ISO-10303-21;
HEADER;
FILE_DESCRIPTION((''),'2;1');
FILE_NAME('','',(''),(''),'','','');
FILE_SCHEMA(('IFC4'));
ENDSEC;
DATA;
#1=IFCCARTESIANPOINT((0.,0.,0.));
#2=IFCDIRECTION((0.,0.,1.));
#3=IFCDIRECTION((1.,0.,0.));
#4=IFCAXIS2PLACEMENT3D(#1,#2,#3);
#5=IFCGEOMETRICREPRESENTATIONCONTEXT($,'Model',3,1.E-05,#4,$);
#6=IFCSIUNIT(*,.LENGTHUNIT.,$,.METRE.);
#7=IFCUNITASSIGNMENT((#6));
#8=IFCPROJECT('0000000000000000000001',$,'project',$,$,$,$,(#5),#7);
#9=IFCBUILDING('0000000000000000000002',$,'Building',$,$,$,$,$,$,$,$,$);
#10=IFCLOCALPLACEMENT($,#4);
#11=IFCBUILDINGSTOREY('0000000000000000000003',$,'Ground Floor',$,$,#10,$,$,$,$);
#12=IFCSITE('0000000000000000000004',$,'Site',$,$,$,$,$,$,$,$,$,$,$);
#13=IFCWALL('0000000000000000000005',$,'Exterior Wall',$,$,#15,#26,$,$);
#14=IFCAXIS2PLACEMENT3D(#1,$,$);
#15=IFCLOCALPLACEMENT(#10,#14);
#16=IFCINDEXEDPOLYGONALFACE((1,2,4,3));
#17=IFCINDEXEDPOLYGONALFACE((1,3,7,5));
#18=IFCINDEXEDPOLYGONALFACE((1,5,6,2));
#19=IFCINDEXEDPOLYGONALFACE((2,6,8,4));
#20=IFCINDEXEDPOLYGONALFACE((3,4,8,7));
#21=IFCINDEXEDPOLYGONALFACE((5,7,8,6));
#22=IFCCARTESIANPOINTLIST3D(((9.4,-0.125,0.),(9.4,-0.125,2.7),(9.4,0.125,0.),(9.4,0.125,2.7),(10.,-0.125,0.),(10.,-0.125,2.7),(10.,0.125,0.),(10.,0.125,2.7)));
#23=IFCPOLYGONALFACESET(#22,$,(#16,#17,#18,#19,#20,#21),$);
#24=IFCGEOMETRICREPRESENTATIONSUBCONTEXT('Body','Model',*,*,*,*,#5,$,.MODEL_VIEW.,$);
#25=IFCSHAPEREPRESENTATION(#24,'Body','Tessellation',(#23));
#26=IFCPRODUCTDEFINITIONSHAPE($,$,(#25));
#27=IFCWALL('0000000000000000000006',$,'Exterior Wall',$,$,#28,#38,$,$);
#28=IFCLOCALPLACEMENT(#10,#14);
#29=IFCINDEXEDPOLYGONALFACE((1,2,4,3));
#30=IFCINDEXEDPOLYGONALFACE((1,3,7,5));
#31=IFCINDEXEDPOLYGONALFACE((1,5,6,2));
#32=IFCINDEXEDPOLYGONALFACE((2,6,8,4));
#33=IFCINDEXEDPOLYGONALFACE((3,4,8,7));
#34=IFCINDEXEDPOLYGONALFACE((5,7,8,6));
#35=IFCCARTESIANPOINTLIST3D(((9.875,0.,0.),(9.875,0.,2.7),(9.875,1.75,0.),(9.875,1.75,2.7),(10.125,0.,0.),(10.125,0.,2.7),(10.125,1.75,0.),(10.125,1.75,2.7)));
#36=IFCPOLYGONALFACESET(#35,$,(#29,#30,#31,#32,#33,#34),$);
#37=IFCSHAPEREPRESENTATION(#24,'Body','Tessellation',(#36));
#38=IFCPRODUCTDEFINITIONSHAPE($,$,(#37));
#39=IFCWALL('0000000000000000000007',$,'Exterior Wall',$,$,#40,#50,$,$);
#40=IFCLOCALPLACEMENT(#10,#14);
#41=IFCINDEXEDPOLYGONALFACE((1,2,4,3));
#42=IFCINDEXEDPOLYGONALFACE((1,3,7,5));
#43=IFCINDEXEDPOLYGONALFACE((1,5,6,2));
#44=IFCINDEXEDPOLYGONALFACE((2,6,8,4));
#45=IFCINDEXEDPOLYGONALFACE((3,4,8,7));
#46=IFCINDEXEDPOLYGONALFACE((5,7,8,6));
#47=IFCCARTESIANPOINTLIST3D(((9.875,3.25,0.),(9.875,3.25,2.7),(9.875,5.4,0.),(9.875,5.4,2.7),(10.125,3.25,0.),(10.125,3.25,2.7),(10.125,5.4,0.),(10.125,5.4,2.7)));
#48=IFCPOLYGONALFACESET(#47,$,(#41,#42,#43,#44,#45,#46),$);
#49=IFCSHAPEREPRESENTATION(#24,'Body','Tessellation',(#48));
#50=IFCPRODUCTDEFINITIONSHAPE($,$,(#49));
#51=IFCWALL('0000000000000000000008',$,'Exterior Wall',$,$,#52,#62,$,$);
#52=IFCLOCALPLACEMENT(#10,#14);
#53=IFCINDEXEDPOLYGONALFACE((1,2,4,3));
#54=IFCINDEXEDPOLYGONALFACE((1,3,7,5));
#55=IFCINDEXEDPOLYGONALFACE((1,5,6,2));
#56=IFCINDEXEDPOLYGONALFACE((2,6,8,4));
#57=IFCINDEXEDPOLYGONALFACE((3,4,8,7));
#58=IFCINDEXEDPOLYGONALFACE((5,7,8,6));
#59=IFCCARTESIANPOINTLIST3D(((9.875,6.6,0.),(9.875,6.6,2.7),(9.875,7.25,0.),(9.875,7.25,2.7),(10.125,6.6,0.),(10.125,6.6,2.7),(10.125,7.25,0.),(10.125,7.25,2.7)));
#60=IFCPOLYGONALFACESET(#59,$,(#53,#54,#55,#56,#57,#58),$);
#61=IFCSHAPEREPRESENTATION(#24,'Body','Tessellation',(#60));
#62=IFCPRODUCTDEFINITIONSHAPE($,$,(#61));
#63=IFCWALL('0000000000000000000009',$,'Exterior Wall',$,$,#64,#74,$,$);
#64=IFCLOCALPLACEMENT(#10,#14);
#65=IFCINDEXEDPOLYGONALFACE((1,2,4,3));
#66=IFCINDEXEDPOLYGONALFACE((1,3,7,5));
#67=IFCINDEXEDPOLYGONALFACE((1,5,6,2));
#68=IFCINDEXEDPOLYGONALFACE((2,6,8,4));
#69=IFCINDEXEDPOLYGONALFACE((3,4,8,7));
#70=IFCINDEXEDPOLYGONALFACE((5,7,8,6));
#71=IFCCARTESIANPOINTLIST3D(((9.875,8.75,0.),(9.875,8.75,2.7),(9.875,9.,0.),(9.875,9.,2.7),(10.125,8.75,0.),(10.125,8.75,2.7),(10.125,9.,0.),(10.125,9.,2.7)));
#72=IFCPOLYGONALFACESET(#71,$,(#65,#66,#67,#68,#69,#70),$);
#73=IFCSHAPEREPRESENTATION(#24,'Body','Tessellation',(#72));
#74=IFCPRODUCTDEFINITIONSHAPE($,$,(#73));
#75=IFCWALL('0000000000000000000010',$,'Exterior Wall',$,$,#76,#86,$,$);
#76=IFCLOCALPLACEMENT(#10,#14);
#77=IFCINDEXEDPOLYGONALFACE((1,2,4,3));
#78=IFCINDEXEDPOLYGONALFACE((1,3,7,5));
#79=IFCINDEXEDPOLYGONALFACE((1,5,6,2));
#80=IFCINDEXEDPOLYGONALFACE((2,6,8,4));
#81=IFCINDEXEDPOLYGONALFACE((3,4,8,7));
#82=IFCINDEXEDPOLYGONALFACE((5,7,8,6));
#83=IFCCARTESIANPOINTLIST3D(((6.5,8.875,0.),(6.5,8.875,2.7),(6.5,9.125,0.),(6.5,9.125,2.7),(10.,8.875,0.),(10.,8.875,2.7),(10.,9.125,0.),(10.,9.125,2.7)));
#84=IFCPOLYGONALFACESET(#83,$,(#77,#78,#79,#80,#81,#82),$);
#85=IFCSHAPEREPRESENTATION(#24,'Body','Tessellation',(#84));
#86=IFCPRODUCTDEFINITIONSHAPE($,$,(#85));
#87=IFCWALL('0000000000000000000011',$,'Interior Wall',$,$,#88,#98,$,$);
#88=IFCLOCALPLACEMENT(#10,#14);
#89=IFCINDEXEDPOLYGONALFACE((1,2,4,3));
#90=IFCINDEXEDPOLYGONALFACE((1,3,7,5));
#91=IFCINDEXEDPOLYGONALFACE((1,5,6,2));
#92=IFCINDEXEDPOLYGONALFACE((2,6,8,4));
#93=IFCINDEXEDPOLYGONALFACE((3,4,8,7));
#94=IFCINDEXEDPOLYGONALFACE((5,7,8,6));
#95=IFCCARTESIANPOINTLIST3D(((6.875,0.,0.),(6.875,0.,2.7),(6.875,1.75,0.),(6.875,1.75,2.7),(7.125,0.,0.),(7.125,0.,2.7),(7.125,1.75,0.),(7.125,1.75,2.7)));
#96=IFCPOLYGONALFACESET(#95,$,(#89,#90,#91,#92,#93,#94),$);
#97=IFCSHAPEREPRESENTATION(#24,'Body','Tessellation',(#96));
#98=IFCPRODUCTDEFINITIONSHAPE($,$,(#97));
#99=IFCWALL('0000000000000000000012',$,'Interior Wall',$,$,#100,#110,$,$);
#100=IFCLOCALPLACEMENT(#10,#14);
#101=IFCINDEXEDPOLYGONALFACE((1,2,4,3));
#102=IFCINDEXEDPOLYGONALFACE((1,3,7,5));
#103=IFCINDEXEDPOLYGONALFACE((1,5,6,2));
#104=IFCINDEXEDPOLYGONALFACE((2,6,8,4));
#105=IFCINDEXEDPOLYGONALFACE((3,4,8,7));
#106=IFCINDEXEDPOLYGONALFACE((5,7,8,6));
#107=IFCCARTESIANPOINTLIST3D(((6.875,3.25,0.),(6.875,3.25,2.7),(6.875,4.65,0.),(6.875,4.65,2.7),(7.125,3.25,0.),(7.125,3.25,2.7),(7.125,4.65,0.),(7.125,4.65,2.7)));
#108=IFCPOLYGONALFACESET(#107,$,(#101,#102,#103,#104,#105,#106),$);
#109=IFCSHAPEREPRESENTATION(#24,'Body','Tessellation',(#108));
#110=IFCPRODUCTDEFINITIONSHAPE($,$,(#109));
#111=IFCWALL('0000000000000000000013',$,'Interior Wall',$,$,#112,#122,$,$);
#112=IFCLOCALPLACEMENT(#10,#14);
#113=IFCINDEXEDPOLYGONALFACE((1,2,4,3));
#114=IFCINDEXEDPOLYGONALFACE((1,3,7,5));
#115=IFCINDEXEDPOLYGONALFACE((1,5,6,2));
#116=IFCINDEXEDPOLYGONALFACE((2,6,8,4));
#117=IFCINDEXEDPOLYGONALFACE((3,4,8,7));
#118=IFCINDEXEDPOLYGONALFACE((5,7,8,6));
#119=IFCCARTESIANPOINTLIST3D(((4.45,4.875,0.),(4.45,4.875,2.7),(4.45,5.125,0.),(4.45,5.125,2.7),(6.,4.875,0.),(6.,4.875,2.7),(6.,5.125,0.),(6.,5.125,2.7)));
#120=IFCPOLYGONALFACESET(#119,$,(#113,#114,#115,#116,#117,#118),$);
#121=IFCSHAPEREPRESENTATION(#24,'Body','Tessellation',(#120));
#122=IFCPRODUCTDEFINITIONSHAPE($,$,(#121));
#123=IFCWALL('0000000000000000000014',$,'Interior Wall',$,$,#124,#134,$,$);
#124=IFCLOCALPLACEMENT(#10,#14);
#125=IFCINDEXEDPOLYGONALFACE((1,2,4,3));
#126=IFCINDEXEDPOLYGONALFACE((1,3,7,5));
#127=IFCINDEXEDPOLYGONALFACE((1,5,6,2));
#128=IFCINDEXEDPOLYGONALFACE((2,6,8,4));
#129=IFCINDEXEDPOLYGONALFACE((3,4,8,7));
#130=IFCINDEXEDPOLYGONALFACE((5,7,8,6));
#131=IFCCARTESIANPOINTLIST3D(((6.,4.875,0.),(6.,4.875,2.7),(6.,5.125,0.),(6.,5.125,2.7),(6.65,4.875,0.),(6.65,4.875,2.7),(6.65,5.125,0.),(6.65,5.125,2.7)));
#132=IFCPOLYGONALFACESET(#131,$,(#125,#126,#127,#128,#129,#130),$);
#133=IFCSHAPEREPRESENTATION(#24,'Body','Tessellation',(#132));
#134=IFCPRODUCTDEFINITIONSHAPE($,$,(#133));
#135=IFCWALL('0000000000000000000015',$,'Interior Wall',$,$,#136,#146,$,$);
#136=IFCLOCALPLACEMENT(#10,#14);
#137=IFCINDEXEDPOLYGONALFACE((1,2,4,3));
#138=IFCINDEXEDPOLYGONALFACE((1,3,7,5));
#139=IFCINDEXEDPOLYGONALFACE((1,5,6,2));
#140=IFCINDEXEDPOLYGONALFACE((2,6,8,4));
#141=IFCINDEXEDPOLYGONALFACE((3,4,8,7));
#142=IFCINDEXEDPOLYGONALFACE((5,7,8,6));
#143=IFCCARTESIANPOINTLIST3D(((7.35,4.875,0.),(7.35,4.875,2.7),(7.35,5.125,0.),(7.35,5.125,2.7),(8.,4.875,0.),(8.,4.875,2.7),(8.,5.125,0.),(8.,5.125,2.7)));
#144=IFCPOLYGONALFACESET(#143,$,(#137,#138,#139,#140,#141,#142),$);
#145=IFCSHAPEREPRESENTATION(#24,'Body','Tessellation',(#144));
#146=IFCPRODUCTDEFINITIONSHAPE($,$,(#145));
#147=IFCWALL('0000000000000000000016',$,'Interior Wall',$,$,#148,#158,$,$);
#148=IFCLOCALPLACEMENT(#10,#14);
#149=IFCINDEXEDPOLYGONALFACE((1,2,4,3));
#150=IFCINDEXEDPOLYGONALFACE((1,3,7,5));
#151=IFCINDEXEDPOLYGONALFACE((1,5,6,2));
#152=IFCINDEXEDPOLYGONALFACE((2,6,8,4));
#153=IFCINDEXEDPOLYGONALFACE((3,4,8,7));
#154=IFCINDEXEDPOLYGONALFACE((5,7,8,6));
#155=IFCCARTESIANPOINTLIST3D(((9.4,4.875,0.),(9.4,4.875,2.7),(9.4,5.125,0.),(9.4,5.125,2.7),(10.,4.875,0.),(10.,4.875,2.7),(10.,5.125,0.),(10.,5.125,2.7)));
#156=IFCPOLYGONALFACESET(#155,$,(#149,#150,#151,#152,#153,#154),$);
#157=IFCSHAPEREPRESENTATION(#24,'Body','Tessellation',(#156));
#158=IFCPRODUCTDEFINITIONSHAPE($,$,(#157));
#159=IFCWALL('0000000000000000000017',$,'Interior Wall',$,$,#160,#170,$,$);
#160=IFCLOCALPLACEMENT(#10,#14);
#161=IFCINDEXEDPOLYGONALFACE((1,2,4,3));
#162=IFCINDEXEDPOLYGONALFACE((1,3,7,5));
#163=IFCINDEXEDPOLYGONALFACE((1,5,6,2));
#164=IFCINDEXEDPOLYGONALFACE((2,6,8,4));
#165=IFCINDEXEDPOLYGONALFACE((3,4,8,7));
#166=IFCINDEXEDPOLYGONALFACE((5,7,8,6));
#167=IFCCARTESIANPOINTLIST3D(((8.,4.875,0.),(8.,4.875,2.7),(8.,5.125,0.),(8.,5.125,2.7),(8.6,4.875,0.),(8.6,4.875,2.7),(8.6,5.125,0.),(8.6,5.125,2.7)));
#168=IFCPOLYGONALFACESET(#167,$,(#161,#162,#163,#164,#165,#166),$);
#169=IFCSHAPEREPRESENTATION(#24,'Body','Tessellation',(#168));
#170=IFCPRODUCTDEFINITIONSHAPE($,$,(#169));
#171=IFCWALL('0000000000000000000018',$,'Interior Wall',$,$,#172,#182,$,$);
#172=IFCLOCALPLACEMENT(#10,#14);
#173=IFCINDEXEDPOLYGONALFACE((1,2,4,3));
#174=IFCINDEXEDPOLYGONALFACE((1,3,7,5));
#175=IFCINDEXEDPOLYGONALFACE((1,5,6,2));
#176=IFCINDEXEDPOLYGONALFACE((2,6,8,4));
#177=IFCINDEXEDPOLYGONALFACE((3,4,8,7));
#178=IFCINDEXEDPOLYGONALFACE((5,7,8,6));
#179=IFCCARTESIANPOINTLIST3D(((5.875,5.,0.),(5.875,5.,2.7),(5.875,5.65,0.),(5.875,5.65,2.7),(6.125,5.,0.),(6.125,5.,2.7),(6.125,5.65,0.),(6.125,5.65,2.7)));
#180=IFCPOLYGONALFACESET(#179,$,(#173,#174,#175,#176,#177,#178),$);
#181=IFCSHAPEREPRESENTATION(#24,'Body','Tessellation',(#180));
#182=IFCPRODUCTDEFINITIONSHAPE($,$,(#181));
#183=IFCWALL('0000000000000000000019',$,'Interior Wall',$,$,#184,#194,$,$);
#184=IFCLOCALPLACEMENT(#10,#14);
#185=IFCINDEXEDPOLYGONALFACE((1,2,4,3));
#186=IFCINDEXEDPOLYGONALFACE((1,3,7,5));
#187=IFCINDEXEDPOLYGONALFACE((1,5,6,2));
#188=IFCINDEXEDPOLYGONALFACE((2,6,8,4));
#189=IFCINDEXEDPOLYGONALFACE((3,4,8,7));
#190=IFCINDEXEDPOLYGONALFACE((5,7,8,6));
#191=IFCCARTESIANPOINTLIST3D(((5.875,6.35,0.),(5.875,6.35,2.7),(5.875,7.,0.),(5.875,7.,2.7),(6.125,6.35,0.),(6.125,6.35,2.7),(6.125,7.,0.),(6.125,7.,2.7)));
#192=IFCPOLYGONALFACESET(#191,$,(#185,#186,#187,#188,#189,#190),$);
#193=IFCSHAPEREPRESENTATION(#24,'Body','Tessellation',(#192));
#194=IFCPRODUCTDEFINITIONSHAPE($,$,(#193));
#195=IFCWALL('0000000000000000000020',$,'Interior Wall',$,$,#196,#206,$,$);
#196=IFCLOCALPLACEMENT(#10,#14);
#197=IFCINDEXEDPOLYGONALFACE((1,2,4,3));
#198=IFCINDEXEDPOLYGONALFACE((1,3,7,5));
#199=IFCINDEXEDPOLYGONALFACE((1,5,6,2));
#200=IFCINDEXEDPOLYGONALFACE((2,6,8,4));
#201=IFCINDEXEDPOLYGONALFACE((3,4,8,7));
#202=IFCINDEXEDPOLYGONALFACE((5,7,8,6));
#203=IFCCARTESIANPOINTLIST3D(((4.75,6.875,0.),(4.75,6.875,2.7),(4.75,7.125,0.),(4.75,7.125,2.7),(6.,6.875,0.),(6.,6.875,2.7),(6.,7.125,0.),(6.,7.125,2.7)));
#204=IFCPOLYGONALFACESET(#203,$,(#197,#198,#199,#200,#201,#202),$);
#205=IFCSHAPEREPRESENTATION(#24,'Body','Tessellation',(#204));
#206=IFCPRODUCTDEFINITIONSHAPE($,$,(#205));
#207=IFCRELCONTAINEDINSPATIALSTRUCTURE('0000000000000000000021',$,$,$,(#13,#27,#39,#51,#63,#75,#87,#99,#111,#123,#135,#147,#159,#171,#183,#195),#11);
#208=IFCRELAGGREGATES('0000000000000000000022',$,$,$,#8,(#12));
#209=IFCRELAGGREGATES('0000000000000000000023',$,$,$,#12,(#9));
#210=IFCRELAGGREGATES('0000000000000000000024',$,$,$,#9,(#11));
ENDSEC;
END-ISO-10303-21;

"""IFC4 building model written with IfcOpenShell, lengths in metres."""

from ifc_helpers import new_model, si_unit, frame, origin_with_axes, place, context, subcontext, project, spatial, indexed_curve, outline, extrude, element, save


model = new_model("IFC4")

# Units and contexts
model_context = context("Model", 3, precision=1e-05, world=origin_with_axes())
body_context = subcontext(model_context, "Body", "Model", "MODEL_VIEW")
ifc_project = project(units=[si_unit("LENGTHUNIT", "METRE")], contexts=[model_context])

# Site, building, storey
site = spatial("IfcSite", under=ifc_project, Name="Site")
building = spatial("IfcBuilding", under=site, Name="Building")
storey_placement = place(None, origin_with_axes())
storey = spatial("IfcBuildingStorey", under=building, at=storey_placement, Name="Ground Floor")

# Walls
wall_1_placement = place(storey_placement, frame((9.4, 0.0, 0.0), z_axis=(0.0, 0.0, 1.0), x_axis=(1.0, 0.0, 0.0)))
element("IfcWall", 1, at=wall_1_placement, inside=storey, Name="Exterior Wall", context=body_context, shape_type="SweptSolid", body=[
    extrude(outline(indexed_curve([(0.0, 0.0), (0.0, 0.25), (0.6, 0.25), (0.6, 0.0), (0.0, 0.0)], self_intersect=False)), frame((0.0, -0.125, 0.0), z_axis=(0.0, 0.0, 1.0), x_axis=(1.0, 0.0, 0.0)), (0.0, 0.0, 1.0), 2.7),
])
wall_2_placement = place(storey_placement, frame((10.0, 0.0, 0.0), z_axis=(0.0, 0.0, 1.0), x_axis=(0.0, 1.0, 0.0)))
element("IfcWall", 2, at=wall_2_placement, inside=storey, Name="Exterior Wall", context=body_context, shape_type="SweptSolid", body=[
    extrude(outline(indexed_curve([(0.0, 0.0), (0.0, 0.25), (1.75, 0.25), (1.75, 0.0), (0.0, 0.0)], self_intersect=False)), frame((0.0, -0.125, 0.0), z_axis=(0.0, 0.0, 1.0), x_axis=(1.0, 0.0, 0.0)), (0.0, 0.0, 1.0), 2.7),
])
wall_3_placement = place(storey_placement, frame((10.0, 3.25, 0.0), z_axis=(0.0, 0.0, 1.0), x_axis=(0.0, 1.0, 0.0)))
element("IfcWall", 3, at=wall_3_placement, inside=storey, Name="Exterior Wall", context=body_context, shape_type="SweptSolid", body=[
    extrude(outline(indexed_curve([(0.0, 0.0), (0.0, 0.25), (2.15, 0.25), (2.15, 0.0), (0.0, 0.0)], self_intersect=False)), frame((0.0, -0.125, 0.0), z_axis=(0.0, 0.0, 1.0), x_axis=(1.0, 0.0, 0.0)), (0.0, 0.0, 1.0), 2.7),
])
wall_4_placement = place(storey_placement, frame((10.0, 6.6, 0.0), z_axis=(0.0, 0.0, 1.0), x_axis=(0.0, 1.0, 0.0)))
element("IfcWall", 4, at=wall_4_placement, inside=storey, Name="Exterior Wall", context=body_context, shape_type="SweptSolid", body=[
    extrude(outline(indexed_curve([(0.0, 0.0), (0.0, 0.25), (0.65, 0.25), (0.65, 0.0), (0.0, 0.0)], self_intersect=False)), frame((0.0, -0.125, 0.0), z_axis=(0.0, 0.0, 1.0), x_axis=(1.0, 0.0, 0.0)), (0.0, 0.0, 1.0), 2.7),
])
wall_5_placement = place(storey_placement, frame((10.0, 8.75, 0.0), z_axis=(0.0, 0.0, 1.0), x_axis=(0.0, 1.0, 0.0)))
element("IfcWall", 5, at=wall_5_placement, inside=storey, Name="Exterior Wall", context=body_context, shape_type="SweptSolid", body=[
    extrude(outline(indexed_curve([(0.0, 0.0), (0.0, 0.25), (0.25, 0.25), (0.25, 0.0), (0.0, 0.0)], self_intersect=False)), frame((0.0, -0.125, 0.0), z_axis=(0.0, 0.0, 1.0), x_axis=(1.0, 0.0, 0.0)), (0.0, 0.0, 1.0), 2.7),
])
wall_6_placement = place(storey_placement, frame((10.0, 9.0, 0.0), z_axis=(0.0, 0.0, 1.0), x_axis=(-1.0, 0.0, 0.0)))
element("IfcWall", 6, at=wall_6_placement, inside=storey, Name="Exterior Wall", context=body_context, shape_type="SweptSolid", body=[
    extrude(outline(indexed_curve([(0.0, 0.0), (0.0, 0.25), (3.5, 0.25), (3.5, 0.0), (0.0, 0.0)], self_intersect=False)), frame((0.0, -0.125, 0.0), z_axis=(0.0, 0.0, 1.0), x_axis=(1.0, 0.0, 0.0)), (0.0, 0.0, 1.0), 2.7),
])
wall_7_placement = place(storey_placement, frame((7.0, 0.0, 0.0), z_axis=(0.0, 0.0, 1.0), x_axis=(0.0, 1.0, 0.0)))
element("IfcWall", 7, at=wall_7_placement, inside=storey, Name="Interior Wall", context=body_context, shape_type="SweptSolid", body=[
    extrude(outline(indexed_curve([(0.0, 0.0), (0.0, 0.25), (1.75, 0.25), (1.75, 0.0), (0.0, 0.0)], self_intersect=False)), frame((0.0, -0.125, 0.0), z_axis=(0.0, 0.0, 1.0), x_axis=(1.0, 0.0, 0.0)), (0.0, 0.0, 1.0), 2.7),
])
wall_8_placement = place(storey_placement, frame((7.0, 3.25, 0.0), z_axis=(0.0, 0.0, 1.0), x_axis=(0.0, 1.0, 0.0)))
element("IfcWall", 8, at=wall_8_placement, inside=storey, Name="Interior Wall", context=body_context, shape_type="SweptSolid", body=[
    extrude(outline(indexed_curve([(0.0, 0.0), (0.0, 0.25), (1.4, 0.25), (1.4, 0.0), (0.0, 0.0)], self_intersect=False)), frame((0.0, -0.125, 0.0), z_axis=(0.0, 0.0, 1.0), x_axis=(1.0, 0.0, 0.0)), (0.0, 0.0, 1.0), 2.7),
])
wall_9_placement = place(storey_placement, frame((6.0, 5.0, 0.0), z_axis=(0.0, 0.0, 1.0), x_axis=(-1.0, 0.0, 0.0)))
element("IfcWall", 9, at=wall_9_placement, inside=storey, Name="Interior Wall", context=body_context, shape_type="SweptSolid", body=[
    extrude(outline(indexed_curve([(0.0, 0.0), (0.0, 0.25), (1.55, 0.25), (1.55, 0.0), (0.0, 0.0)], self_intersect=False)), frame((0.0, -0.125, 0.0), z_axis=(0.0, 0.0, 1.0), x_axis=(1.0, 0.0, 0.0)), (0.0, 0.0, 1.0), 2.7),
])
for number, where, z_axis, x_axis, name in (
    (10, (6.65, 5.0, 0.0), (0.0, 0.0, 1.0), (-1.0, 0.0, 0.0), "Interior Wall"),
    (11, (8.0, 5.0, 0.0), (0.0, 0.0, 1.0), (-1.0, 0.0, 0.0), "Interior Wall"),
):
    element("IfcWall", number, at=place(storey_placement, frame(where, z_axis=z_axis, x_axis=x_axis)), inside=storey, Name=name, context=body_context, shape_type="SweptSolid", body=[
        extrude(outline(indexed_curve([(0.0, 0.0), (0.0, 0.25), (0.65, 0.25), (0.65, 0.0), (0.0, 0.0)], self_intersect=False)), frame((0.0, -0.125, 0.0), z_axis=(0.0, 0.0, 1.0), x_axis=(1.0, 0.0, 0.0)), (0.0, 0.0, 1.0), 2.7),
    ])
for number, where, z_axis, x_axis, name in (
    (12, (10.0, 5.0, 0.0), (0.0, 0.0, 1.0), (-1.0, 0.0, 0.0), "Interior Wall"),
    (13, (8.6, 5.0, 0.0), (0.0, 0.0, 1.0), (-1.0, 0.0, 0.0), "Interior Wall"),
):
    element("IfcWall", number, at=place(storey_placement, frame(where, z_axis=z_axis, x_axis=x_axis)), inside=storey, Name=name, context=body_context, shape_type="SweptSolid", body=[
        extrude(outline(indexed_curve([(0.0, 0.0), (0.0, 0.25), (0.6, 0.25), (0.6, 0.0), (0.0, 0.0)], self_intersect=False)), frame((0.0, -0.125, 0.0), z_axis=(0.0, 0.0, 1.0), x_axis=(1.0, 0.0, 0.0)), (0.0, 0.0, 1.0), 2.7),
    ])
for number, where, z_axis, x_axis, name in (
    (14, (6.0, 5.0, 0.0), (0.0, 0.0, 1.0), (0.0, 1.0, 0.0), "Interior Wall"),
    (15, (6.0, 6.35, 0.0), (0.0, 0.0, 1.0), (0.0, 1.0, 0.0), "Interior Wall"),
):
    element("IfcWall", number, at=place(storey_placement, frame(where, z_axis=z_axis, x_axis=x_axis)), inside=storey, Name=name, context=body_context, shape_type="SweptSolid", body=[
        extrude(outline(indexed_curve([(0.0, 0.0), (0.0, 0.25), (0.65, 0.25), (0.65, 0.0), (0.0, 0.0)], self_intersect=False)), frame((0.0, -0.125, 0.0), z_axis=(0.0, 0.0, 1.0), x_axis=(1.0, 0.0, 0.0)), (0.0, 0.0, 1.0), 2.7),
    ])
wall_10_placement = place(storey_placement, frame((6.0, 7.0, 0.0), z_axis=(0.0, 0.0, 1.0), x_axis=(-1.0, 0.0, 0.0)))
element("IfcWall", 16, at=wall_10_placement, inside=storey, Name="Interior Wall", context=body_context, shape_type="SweptSolid", body=[
    extrude(outline(indexed_curve([(0.0, 0.0), (0.0, 0.25), (1.25, 0.25), (1.25, 0.0), (0.0, 0.0)], self_intersect=False)), frame((0.0, -0.125, 0.0), z_axis=(0.0, 0.0, 1.0), x_axis=(1.0, 0.0, 0.0)), (0.0, 0.0, 1.0), 2.7),
])

save(model, "model.ifc")
